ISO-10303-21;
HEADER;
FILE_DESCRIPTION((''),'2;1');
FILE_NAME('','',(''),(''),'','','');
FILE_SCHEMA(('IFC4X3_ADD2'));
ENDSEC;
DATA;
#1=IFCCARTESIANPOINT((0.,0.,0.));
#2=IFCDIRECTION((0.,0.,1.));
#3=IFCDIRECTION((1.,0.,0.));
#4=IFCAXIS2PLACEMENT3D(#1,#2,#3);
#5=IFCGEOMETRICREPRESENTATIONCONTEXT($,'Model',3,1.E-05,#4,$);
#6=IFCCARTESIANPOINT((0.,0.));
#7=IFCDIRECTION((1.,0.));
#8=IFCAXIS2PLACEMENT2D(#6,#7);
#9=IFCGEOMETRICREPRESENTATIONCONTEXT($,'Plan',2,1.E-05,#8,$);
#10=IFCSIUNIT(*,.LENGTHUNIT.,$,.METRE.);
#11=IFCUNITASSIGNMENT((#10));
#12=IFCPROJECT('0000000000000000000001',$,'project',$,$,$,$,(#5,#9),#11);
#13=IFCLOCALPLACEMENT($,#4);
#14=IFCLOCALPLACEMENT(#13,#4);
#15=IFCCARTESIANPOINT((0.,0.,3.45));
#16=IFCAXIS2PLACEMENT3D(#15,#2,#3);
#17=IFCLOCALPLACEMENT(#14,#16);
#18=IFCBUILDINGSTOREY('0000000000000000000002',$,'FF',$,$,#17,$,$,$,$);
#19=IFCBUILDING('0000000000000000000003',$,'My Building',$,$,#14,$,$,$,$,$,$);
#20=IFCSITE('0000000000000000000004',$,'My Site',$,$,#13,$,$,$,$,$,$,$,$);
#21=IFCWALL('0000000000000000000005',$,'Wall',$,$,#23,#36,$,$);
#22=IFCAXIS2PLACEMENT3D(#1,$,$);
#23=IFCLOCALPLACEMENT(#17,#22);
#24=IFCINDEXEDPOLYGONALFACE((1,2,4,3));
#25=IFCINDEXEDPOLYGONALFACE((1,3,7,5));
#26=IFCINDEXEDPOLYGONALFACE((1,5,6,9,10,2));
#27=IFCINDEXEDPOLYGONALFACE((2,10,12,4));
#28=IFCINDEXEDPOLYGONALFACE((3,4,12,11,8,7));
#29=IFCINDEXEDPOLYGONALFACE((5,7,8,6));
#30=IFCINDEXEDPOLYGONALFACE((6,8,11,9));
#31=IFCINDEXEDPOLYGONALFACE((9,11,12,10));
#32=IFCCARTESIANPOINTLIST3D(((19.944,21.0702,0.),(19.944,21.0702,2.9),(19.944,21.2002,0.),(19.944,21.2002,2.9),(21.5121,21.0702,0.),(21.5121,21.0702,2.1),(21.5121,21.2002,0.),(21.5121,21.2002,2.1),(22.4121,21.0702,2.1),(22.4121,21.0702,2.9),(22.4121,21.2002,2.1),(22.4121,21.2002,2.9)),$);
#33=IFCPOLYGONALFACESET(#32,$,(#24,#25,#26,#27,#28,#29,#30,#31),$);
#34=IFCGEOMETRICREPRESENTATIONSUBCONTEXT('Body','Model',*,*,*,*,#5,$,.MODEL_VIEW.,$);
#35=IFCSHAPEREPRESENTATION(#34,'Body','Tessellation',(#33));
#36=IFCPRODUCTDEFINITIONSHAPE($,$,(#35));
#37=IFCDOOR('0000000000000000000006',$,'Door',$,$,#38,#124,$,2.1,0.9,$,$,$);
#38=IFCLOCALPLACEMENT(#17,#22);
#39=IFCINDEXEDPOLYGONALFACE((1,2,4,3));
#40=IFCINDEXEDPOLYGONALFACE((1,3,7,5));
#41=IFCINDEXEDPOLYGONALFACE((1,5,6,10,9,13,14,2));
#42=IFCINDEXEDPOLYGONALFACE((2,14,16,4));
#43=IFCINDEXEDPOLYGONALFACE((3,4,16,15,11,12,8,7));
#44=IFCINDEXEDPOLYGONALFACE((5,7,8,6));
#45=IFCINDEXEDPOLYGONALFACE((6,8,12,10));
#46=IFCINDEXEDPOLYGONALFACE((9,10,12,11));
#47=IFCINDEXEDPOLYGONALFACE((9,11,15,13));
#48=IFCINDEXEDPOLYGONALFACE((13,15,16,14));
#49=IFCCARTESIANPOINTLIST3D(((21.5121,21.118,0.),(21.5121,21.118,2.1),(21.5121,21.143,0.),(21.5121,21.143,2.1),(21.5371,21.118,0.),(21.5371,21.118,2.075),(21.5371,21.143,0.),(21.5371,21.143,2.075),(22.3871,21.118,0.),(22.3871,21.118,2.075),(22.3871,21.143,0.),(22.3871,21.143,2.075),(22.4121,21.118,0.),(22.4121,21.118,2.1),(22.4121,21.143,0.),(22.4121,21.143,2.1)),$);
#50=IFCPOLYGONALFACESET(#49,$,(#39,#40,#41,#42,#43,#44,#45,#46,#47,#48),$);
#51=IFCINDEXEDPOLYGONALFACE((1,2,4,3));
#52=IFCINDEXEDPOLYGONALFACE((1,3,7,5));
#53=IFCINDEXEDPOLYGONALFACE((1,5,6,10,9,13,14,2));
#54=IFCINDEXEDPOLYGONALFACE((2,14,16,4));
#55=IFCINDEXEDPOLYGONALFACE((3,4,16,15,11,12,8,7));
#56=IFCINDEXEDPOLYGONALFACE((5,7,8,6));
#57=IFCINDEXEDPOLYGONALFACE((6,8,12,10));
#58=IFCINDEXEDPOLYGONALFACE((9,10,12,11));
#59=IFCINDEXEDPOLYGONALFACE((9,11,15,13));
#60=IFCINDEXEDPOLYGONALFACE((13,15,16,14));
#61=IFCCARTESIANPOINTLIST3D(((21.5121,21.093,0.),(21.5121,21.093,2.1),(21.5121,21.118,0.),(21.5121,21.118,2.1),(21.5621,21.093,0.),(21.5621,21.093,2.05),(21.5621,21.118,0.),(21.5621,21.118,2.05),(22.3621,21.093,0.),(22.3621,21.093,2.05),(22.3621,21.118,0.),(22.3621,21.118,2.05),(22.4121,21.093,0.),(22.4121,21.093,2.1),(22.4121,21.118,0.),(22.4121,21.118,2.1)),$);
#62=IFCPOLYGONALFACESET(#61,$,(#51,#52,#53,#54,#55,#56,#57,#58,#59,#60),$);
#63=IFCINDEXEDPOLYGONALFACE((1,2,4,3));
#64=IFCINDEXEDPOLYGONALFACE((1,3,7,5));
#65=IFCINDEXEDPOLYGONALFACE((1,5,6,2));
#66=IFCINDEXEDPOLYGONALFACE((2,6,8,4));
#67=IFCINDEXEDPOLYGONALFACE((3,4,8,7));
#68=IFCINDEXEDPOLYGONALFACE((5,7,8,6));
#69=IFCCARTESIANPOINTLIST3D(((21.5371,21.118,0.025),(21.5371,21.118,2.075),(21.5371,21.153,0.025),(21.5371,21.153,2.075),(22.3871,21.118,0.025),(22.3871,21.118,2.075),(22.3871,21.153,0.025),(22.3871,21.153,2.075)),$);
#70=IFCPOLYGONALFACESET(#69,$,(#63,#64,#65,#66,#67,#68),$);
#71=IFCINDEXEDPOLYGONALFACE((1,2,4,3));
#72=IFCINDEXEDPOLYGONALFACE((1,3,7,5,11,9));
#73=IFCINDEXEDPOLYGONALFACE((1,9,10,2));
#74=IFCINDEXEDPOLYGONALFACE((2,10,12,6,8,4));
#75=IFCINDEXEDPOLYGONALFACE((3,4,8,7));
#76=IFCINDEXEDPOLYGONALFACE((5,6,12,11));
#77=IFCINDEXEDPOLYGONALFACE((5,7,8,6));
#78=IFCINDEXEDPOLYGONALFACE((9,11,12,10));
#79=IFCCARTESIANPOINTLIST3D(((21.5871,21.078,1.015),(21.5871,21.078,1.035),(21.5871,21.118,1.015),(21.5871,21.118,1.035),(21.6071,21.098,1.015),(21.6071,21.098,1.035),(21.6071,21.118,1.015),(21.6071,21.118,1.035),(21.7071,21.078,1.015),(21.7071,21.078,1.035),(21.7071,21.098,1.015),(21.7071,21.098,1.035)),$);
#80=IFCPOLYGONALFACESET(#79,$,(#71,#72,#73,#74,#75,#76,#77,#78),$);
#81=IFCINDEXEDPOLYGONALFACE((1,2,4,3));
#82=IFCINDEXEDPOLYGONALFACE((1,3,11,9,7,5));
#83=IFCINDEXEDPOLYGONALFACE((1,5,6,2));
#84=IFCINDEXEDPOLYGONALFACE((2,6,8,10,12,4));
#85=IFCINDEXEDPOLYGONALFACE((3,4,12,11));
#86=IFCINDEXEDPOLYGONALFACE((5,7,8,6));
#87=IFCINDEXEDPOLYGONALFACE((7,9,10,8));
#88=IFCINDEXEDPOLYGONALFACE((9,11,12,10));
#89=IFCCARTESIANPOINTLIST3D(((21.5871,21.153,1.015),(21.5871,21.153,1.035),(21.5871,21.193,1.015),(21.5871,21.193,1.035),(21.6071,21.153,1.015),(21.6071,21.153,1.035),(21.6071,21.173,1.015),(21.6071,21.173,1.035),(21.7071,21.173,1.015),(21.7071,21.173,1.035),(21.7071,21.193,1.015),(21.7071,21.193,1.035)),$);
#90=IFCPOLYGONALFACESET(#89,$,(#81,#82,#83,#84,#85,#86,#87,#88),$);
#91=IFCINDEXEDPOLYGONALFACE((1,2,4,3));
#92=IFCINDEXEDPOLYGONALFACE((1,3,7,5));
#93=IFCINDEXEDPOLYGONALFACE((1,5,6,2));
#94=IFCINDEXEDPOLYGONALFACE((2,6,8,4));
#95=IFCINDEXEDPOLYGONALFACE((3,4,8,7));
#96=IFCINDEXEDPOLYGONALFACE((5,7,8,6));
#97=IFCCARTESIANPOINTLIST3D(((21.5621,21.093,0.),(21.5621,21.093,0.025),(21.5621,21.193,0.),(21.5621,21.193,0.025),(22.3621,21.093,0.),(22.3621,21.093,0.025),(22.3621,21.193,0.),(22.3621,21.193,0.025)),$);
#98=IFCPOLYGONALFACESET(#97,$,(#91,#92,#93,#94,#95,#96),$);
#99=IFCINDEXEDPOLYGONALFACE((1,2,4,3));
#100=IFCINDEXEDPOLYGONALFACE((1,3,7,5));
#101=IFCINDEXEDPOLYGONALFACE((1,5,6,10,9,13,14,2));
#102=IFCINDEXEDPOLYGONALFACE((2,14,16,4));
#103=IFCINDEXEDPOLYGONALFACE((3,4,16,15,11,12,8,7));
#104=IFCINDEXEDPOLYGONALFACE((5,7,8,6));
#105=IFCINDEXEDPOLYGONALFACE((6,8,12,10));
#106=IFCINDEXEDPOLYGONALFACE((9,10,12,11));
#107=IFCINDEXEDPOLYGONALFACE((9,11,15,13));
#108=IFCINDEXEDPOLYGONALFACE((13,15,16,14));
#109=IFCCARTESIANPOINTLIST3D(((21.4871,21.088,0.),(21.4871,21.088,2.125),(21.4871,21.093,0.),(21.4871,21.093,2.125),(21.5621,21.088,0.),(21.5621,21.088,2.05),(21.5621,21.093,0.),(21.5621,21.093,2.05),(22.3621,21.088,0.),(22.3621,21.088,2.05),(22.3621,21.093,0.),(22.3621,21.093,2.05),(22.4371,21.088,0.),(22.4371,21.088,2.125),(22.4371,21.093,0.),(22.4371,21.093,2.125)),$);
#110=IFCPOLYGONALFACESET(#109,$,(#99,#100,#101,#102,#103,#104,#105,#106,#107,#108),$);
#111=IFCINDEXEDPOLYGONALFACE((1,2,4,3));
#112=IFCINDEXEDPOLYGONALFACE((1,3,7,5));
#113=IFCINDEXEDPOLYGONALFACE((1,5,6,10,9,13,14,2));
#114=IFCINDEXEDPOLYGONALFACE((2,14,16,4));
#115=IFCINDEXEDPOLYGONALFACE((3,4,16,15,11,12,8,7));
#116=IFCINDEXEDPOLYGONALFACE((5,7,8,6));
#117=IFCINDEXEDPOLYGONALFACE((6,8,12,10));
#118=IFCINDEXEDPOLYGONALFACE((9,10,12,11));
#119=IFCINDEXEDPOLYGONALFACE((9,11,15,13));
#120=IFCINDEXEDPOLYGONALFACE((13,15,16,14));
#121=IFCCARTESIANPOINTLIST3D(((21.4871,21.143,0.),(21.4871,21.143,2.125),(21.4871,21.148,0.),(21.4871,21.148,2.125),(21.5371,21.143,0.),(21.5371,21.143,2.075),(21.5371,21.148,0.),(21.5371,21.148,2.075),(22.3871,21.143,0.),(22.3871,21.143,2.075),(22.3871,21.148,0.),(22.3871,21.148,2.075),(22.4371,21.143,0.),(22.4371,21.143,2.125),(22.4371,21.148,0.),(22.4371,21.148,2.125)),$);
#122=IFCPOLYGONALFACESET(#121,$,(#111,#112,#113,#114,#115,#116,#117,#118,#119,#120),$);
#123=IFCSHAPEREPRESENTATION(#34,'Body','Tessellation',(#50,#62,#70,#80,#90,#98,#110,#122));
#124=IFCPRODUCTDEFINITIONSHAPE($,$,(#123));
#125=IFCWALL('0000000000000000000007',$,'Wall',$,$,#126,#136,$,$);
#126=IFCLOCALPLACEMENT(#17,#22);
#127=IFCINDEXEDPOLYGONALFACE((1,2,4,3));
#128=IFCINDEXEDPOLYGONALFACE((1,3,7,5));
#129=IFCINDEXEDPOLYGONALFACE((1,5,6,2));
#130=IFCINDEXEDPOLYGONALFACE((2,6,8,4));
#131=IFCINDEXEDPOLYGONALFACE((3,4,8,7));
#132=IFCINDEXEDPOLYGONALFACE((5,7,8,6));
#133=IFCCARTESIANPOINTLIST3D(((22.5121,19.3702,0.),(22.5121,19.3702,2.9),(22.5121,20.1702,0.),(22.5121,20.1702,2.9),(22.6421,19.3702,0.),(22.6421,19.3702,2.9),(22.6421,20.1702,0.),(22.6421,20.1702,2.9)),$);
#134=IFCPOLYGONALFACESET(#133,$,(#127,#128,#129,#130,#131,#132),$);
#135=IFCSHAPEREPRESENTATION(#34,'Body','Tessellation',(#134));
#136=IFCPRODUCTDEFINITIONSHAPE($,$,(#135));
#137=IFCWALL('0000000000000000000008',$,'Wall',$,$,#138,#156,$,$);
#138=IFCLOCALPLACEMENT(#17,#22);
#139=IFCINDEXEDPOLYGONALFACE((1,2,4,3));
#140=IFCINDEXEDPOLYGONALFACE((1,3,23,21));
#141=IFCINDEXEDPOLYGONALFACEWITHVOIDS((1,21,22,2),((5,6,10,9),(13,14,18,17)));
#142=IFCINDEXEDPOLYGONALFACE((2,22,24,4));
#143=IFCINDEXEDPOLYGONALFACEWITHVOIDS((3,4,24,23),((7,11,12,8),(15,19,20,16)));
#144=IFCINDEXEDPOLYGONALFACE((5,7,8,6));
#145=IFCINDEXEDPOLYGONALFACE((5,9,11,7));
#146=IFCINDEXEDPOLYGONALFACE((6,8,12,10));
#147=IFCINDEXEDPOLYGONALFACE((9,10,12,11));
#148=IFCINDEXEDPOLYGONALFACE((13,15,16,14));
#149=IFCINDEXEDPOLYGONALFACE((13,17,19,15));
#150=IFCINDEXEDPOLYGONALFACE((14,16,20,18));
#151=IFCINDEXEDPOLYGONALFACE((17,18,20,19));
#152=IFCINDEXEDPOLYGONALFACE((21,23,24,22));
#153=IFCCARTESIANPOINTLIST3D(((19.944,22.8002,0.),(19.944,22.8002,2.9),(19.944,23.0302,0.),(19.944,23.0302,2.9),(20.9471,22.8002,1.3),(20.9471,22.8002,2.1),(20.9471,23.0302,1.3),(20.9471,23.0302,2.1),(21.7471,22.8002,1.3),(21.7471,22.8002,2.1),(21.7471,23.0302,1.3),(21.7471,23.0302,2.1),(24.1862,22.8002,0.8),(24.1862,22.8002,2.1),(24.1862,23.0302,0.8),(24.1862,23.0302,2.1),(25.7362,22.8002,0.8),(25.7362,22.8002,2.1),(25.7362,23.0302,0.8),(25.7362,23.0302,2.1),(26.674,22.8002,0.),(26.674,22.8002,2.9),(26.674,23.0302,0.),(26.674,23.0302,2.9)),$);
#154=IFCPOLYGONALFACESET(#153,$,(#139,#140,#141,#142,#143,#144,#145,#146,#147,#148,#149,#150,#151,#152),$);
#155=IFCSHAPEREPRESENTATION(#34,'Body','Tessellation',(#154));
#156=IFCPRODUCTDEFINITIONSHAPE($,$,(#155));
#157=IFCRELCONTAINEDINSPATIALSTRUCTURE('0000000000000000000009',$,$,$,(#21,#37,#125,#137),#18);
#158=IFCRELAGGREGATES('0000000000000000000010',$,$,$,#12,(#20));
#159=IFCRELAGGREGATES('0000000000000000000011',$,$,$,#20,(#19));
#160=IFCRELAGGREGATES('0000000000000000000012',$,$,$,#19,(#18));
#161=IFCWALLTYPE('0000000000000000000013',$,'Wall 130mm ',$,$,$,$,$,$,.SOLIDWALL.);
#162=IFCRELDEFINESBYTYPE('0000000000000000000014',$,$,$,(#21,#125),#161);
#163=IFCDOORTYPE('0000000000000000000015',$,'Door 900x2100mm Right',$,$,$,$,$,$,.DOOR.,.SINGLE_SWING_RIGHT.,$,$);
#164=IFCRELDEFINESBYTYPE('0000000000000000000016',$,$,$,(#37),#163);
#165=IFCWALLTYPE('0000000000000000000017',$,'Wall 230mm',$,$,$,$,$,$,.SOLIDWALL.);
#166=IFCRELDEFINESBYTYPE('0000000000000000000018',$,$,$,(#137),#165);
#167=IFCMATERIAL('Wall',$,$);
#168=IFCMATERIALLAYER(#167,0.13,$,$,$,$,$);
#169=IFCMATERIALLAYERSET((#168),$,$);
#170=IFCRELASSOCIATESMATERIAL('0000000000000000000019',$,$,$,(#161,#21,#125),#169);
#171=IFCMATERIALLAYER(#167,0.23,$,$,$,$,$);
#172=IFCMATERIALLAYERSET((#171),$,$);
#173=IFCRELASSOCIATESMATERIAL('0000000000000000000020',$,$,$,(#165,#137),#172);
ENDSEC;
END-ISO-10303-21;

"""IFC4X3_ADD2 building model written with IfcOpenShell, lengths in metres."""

from ifc_helpers import new_model, entity, si_unit, frame, origin_with_axes, origin_2d_with_axis, place, context, subcontext, project, spatial, line, indexed_curve, outline, extrude, shape, source, transform, mapped, material, layer, layer_set, layer_usage, type_object, type_shapes, element, fill, save


model = new_model("IFC4X3_ADD2")

# Units and contexts
model_context = context("Model", 3, precision=1e-05, world=origin_with_axes())
plan_context = context("Plan", 2, precision=1e-05, world=origin_2d_with_axis())
body_context_1 = subcontext(model_context, "Body", "Model", "MODEL_VIEW")
body_context_2 = subcontext(plan_context, "Body", "Plan", "PLAN_VIEW")
ifc_project = project(units=[si_unit("LENGTHUNIT", "METRE")], contexts=[model_context, plan_context])

# Site, building, storey
site_placement = place(None, origin_with_axes())
site = spatial("IfcSite", under=ifc_project, at=site_placement, Name="My Site")
building_placement = place(site_placement, origin_with_axes())
building = spatial("IfcBuilding", under=site, at=building_placement, Name="My Building")
storey_placement = place(building_placement, frame((0.0, 0.0, 3.45), z_axis=(0.0, 0.0, 1.0), x_axis=(1.0, 0.0, 0.0)))
storey = spatial("IfcBuildingStorey", under=building, at=storey_placement, Name="FF")

# Wall, opening, door
ifc_material = material(Name="Wall")
ifc_layer_1 = layer(ifc_material, 0.13)
ifc_layer_set_1 = layer_set([ifc_layer_1])
ifc_layer_usage_1 = layer_usage(ifc_layer_set_1, "AXIS2", "POSITIVE", 0.0)
wall_type_1 = type_object("IfcWallType", Name="Wall 130mm ", PredefinedType="SOLIDWALL", material=ifc_layer_set_1)
wall_1_placement = place(storey_placement, frame((22.4121, 21.2002, 0.0), z_axis=(0.0, 0.0, 1.0), x_axis=(-1.0, 0.0, 0.0)))
wall_1 = element("IfcWall", 1, at=wall_1_placement, inside=storey, type_object=wall_type_1, material=ifc_layer_usage_1, Name="Wall", context=body_context_1, shape_type="SweptSolid", body=[
    extrude(outline(indexed_curve([(0.0, 0.0), (0.0, 0.13), (2.4681, 0.13), (2.4681, 0.0), (0.0, 0.0)], self_intersect=False)), origin_with_axes(), (0.0, 0.0, 1.0), 2.9),
])
shared_shape_1 = source(origin_with_axes(), body_context_1, "Body", "SweptSolid", [
    extrude(outline(indexed_curve([(0.0, 0.0), (0.9, 0.0), (0.9, 2.1), (0.0, 2.1)], segments=[line(1, 2, 3, 4, 1)])), frame((0.0, -0.6, 0.0), z_axis=(0.0, -1.0, 0.0), x_axis=(1.0, 0.0, 0.0)), (0.0, 0.0, -1.0), 1.2),
])
opening_1_placement = place(wall_1_placement, frame((0.9, 0.1072, 0.0), z_axis=(0.0, 0.0, 1.0), x_axis=(-1.0, 0.0, 0.0)))
opening_1 = element("IfcOpeningElement", 2, at=opening_1_placement, cuts=wall_1, PredefinedType="OPENING", context=body_context_1, shape_type="MappedRepresentation", body=[
    mapped(shared_shape_1, transform((0.0, 0.0, 0.0), x_axis=(1.0, 0.0, 0.0), y_axis=(0.0, 1.0, 0.0), z_axis=(0.0, 0.0, 1.0), scale=1.0)),
])
door_type_1 = type_object("IfcDoorType", Name="Door 900x2100mm Right", OperationType="SINGLE_SWING_RIGHT", PredefinedType="DOOR")
shared_shape_2 = source(origin_with_axes(), body_context_1, "Body", "SweptSolid", [
    extrude(outline(indexed_curve([(0.0, 0.0), (0.0, 2.1), (0.9, 2.1), (0.9, 0.0), (0.875, 0.0), (0.875, 2.075), (0.025, 2.075), (0.025, 0.0)], segments=[line(1, 2, 3, 4, 5, 6, 7, 8, 1)])), frame((0.0, 0.025, 0.0), z_axis=(0.0, -1.0, 0.0), x_axis=(1.0, 0.0, 0.0)), (0.0, 0.0, -1.0), 0.025),
    extrude(outline(indexed_curve([(0.0, 0.0), (0.0, 2.1), (0.9, 2.1), (0.9, 0.0), (0.85, 0.0), (0.85, 2.05), (0.05, 2.05), (0.05, 0.0)], segments=[line(1, 2, 3, 4, 5, 6, 7, 8, 1)])), frame((0.0, 0.0, 0.0), z_axis=(0.0, -1.0, 0.0), x_axis=(1.0, 0.0, 0.0)), (0.0, 0.0, -1.0), 0.025),
    extrude(outline(indexed_curve([(0.0, 0.0), (0.85, 0.0), (0.85, 0.035), (0.0, 0.035)], segments=[line(1, 2, 3, 4, 1)])), frame((0.025, 0.025, 0.025), z_axis=(0.0, 0.0, 1.0), x_axis=(1.0, 0.0, 0.0)), (0.0, 0.0, 1.0), 2.05),
    extrude(outline(indexed_curve([(0.0, 0.0), (0.0, -0.04), (0.12, -0.04), (0.12, -0.02), (0.02, -0.02), (0.02, 0.0)], segments=[line(1, 2, 3, 4, 5, 6, 1)])), frame((0.075, 0.025, 1.015), z_axis=(0.0, 0.0, 1.0), x_axis=(1.0, 0.0, 0.0)), (0.0, 0.0, 1.0), 0.02),
    extrude(outline(indexed_curve([(0.0, 0.0), (0.0, 0.04), (0.12, 0.04), (0.12, 0.02), (0.02, 0.02), (0.02, 0.0)], segments=[line(1, 2, 3, 4, 5, 6, 1)])), frame((0.075, 0.06, 1.015), z_axis=(0.0, 0.0, 1.0), x_axis=(1.0, 0.0, 0.0)), (0.0, 0.0, 1.0), 0.02),
    extrude(outline(indexed_curve([(0.0, 0.0), (0.8, 0.0), (0.8, 0.1), (0.0, 0.1)], segments=[line(1, 2, 3, 4, 1)])), frame((0.05, 0.0, 0.0), z_axis=(0.0, 0.0, 1.0), x_axis=(1.0, 0.0, 0.0)), (0.0, 0.0, 1.0), 0.025),
    extrude(outline(indexed_curve([(0.0, 0.0), (0.0, 2.125), (0.95, 2.125), (0.95, 0.0), (0.875, 0.0), (0.875, 2.05), (0.075, 2.05), (0.075, 0.0)], segments=[line(1, 2, 3, 4, 5, 6, 7, 8, 1)])), frame((-0.025, -0.005, 0.0), z_axis=(0.0, -1.0, 0.0), x_axis=(1.0, 0.0, 0.0)), (0.0, 0.0, -1.0), 0.005),
    extrude(outline(indexed_curve([(0.0, 0.0), (0.0, 2.125), (0.95, 2.125), (0.95, 0.0), (0.9, 0.0), (0.9, 2.075), (0.05, 2.075), (0.05, 0.0)], segments=[line(1, 2, 3, 4, 5, 6, 7, 8, 1)])), frame((-0.025, 0.05, 0.0), z_axis=(0.0, -1.0, 0.0), x_axis=(1.0, 0.0, 0.0)), (0.0, 0.0, -1.0), 0.005),
])
shared_shape_3 = source(origin_with_axes(), body_context_2, "Body", "Curve2D", [
    entity("IfcIndexedPolyCurve", entity("IfcCartesianPointList2D", [[0.0, 0.0], [0.0, 0.05], [0.025, 0.05], [0.025, 0.025], [0.05, 0.025], [0.05, 0.0]]), [entity("IfcLineIndex", [1, 2, 3, 4, 5, 6, 1])]),
    entity("IfcIndexedPolyCurve", entity("IfcCartesianPointList2D", [[0.9, 0.0], [0.9, 0.05], [0.875, 0.05], [0.875, 0.025], [0.85, 0.025], [0.85, 0.0]]), [entity("IfcLineIndex", [1, 2, 3, 4, 5, 6, 1])]),
    entity("IfcTrimmedCurve", entity("IfcEllipse", entity("IfcAxis2Placement2D", entity("IfcCartesianPoint", [0.84, 0.05]), entity("IfcDirection", [1.0, 0.0])), 0.815, 0.85), [entity("IfcCartesianPoint", [0.84, 0.9])], [entity("IfcCartesianPoint", [0.025, 0.05])], True, "CARTESIAN"),
    entity("IfcIndexedPolyCurve", entity("IfcCartesianPointList2D", [[0.875, 0.05], [0.84, 0.05], [0.84, 0.9], [0.875, 0.9]]), [entity("IfcLineIndex", [1, 2, 3, 4, 1])]),
])
type_shapes(door_type_1, [shared_shape_2, shared_shape_3])
door_1_placement = place(opening_1_placement, frame((0.0, 0.0, 0.0), z_axis=(0.0, 0.0, 1.0), x_axis=(1.0, 0.0, 0.0)))
door_1 = element("IfcDoor", 3, at=door_1_placement, inside=storey, type_object=door_type_1, Name="Door", OverallHeight=2.1, OverallWidth=0.9, shapes=[
    shape(body_context_1, "Body", "MappedRepresentation", [mapped(shared_shape_2, transform((0.0, 0.0, 0.0), x_axis=(1.0, 0.0, 0.0), y_axis=(0.0, 1.0, 0.0), z_axis=(0.0, 0.0, 1.0), scale=1.0))]),
    shape(body_context_2, "Body", "MappedRepresentation", [mapped(shared_shape_3, transform((0.0, 0.0, 0.0), x_axis=(1.0, 0.0, 0.0), y_axis=(0.0, 1.0, 0.0), z_axis=(0.0, 0.0, 1.0), scale=1.0))]),
])
fill(opening_1, door_1)

# Wall
ifc_layer_usage_2 = layer_usage(ifc_layer_set_1, "AXIS2", "POSITIVE", 0.0)
wall_2_placement = place(storey_placement, frame((22.6421, 19.3702, 0.0), z_axis=(0.0, 0.0, 1.0), x_axis=(0.000001, 1.0, 0.0)))
element("IfcWall", 4, at=wall_2_placement, inside=storey, type_object=wall_type_1, material=ifc_layer_usage_2, Name="Wall", context=body_context_1, shape_type="SweptSolid", body=[
    extrude(outline(indexed_curve([(0.0, 0.0), (0.0, 0.13), (0.8, 0.13), (0.8, 0.0), (0.0, 0.0)], self_intersect=False)), origin_with_axes(), (0.0, 0.0, 1.0), 2.9),
])

# Wall, openings
ifc_layer_2 = layer(ifc_material, 0.23)
ifc_layer_set_2 = layer_set([ifc_layer_2])
ifc_layer_usage_3 = layer_usage(ifc_layer_set_2, "AXIS2", "POSITIVE", 0.0)
wall_type_2 = type_object("IfcWallType", Name="Wall 230mm", PredefinedType="SOLIDWALL", material=ifc_layer_set_2)
wall_3_placement = place(storey_placement, frame((26.674, 23.0302, 0.0), z_axis=(0.0, 0.0, 1.0), x_axis=(-1.0, 0.0, 0.0)))
wall_3 = element("IfcWall", 5, at=wall_3_placement, inside=storey, type_object=wall_type_2, material=ifc_layer_usage_3, Name="Wall", context=body_context_1, shape_type="SweptSolid", body=[
    extrude(outline(indexed_curve([(0.0, 0.0), (0.0, 0.23), (6.73, 0.23), (6.73, 0.0), (0.0, 0.0)], self_intersect=False)), origin_with_axes(), (0.0, 0.0, 1.0), 2.9),
])
shared_shape_4 = source(origin_with_axes(), body_context_1, "Body", "SweptSolid", [
    extrude(outline(indexed_curve([(0.0, 0.0), (1.55, 0.0), (1.55, 1.3), (0.0, 1.3)], segments=[line(1, 2, 3, 4, 1)])), frame((-0.775, -0.6, 0.0), z_axis=(0.0, -1.0, 0.0), x_axis=(1.0, 0.0, 0.0)), (0.0, 0.0, -1.0), 1.2),
])
opening_2_placement = place(wall_3_placement, frame((1.7127, 0.0, 0.8), z_axis=(0.0, 0.0, 1.0), x_axis=(1.0, 0.0, 0.0)))
element("IfcOpeningElement", 6, at=opening_2_placement, cuts=wall_3, PredefinedType="OPENING", context=body_context_1, shape_type="MappedRepresentation", body=[
    mapped(shared_shape_4, transform((0.0, 0.0, 0.0), x_axis=(1.0, 0.0, 0.0), y_axis=(0.0, 1.0, 0.0), z_axis=(0.0, 0.0, 1.0), scale=1.0)),
])
shared_shape_5 = source(origin_with_axes(), body_context_1, "Body", "SweptSolid", [
    extrude(outline(indexed_curve([(0.0, 0.0), (0.8, 0.0), (0.8, 0.8), (0.0, 0.8)], segments=[line(1, 2, 3, 4, 1)])), frame((-0.4, -0.6, 0.0), z_axis=(0.0, -1.0, 0.0), x_axis=(1.0, 0.0, 0.0)), (0.0, 0.0, -1.0), 1.2),
])
opening_3_placement = place(wall_3_placement, frame((5.3269, 0.0, 1.3), z_axis=(0.0, 0.0, 1.0), x_axis=(1.0, 0.0, 0.0)))
element("IfcOpeningElement", 7, at=opening_3_placement, cuts=wall_3, PredefinedType="OPENING", context=body_context_1, shape_type="MappedRepresentation", body=[
    mapped(shared_shape_5, transform((0.0, 0.0, 0.0), x_axis=(1.0, 0.0, 0.0), y_axis=(0.0, 1.0, 0.0), z_axis=(0.0, 0.0, 1.0), scale=1.0)),
])

save(model, "model.ifc")
